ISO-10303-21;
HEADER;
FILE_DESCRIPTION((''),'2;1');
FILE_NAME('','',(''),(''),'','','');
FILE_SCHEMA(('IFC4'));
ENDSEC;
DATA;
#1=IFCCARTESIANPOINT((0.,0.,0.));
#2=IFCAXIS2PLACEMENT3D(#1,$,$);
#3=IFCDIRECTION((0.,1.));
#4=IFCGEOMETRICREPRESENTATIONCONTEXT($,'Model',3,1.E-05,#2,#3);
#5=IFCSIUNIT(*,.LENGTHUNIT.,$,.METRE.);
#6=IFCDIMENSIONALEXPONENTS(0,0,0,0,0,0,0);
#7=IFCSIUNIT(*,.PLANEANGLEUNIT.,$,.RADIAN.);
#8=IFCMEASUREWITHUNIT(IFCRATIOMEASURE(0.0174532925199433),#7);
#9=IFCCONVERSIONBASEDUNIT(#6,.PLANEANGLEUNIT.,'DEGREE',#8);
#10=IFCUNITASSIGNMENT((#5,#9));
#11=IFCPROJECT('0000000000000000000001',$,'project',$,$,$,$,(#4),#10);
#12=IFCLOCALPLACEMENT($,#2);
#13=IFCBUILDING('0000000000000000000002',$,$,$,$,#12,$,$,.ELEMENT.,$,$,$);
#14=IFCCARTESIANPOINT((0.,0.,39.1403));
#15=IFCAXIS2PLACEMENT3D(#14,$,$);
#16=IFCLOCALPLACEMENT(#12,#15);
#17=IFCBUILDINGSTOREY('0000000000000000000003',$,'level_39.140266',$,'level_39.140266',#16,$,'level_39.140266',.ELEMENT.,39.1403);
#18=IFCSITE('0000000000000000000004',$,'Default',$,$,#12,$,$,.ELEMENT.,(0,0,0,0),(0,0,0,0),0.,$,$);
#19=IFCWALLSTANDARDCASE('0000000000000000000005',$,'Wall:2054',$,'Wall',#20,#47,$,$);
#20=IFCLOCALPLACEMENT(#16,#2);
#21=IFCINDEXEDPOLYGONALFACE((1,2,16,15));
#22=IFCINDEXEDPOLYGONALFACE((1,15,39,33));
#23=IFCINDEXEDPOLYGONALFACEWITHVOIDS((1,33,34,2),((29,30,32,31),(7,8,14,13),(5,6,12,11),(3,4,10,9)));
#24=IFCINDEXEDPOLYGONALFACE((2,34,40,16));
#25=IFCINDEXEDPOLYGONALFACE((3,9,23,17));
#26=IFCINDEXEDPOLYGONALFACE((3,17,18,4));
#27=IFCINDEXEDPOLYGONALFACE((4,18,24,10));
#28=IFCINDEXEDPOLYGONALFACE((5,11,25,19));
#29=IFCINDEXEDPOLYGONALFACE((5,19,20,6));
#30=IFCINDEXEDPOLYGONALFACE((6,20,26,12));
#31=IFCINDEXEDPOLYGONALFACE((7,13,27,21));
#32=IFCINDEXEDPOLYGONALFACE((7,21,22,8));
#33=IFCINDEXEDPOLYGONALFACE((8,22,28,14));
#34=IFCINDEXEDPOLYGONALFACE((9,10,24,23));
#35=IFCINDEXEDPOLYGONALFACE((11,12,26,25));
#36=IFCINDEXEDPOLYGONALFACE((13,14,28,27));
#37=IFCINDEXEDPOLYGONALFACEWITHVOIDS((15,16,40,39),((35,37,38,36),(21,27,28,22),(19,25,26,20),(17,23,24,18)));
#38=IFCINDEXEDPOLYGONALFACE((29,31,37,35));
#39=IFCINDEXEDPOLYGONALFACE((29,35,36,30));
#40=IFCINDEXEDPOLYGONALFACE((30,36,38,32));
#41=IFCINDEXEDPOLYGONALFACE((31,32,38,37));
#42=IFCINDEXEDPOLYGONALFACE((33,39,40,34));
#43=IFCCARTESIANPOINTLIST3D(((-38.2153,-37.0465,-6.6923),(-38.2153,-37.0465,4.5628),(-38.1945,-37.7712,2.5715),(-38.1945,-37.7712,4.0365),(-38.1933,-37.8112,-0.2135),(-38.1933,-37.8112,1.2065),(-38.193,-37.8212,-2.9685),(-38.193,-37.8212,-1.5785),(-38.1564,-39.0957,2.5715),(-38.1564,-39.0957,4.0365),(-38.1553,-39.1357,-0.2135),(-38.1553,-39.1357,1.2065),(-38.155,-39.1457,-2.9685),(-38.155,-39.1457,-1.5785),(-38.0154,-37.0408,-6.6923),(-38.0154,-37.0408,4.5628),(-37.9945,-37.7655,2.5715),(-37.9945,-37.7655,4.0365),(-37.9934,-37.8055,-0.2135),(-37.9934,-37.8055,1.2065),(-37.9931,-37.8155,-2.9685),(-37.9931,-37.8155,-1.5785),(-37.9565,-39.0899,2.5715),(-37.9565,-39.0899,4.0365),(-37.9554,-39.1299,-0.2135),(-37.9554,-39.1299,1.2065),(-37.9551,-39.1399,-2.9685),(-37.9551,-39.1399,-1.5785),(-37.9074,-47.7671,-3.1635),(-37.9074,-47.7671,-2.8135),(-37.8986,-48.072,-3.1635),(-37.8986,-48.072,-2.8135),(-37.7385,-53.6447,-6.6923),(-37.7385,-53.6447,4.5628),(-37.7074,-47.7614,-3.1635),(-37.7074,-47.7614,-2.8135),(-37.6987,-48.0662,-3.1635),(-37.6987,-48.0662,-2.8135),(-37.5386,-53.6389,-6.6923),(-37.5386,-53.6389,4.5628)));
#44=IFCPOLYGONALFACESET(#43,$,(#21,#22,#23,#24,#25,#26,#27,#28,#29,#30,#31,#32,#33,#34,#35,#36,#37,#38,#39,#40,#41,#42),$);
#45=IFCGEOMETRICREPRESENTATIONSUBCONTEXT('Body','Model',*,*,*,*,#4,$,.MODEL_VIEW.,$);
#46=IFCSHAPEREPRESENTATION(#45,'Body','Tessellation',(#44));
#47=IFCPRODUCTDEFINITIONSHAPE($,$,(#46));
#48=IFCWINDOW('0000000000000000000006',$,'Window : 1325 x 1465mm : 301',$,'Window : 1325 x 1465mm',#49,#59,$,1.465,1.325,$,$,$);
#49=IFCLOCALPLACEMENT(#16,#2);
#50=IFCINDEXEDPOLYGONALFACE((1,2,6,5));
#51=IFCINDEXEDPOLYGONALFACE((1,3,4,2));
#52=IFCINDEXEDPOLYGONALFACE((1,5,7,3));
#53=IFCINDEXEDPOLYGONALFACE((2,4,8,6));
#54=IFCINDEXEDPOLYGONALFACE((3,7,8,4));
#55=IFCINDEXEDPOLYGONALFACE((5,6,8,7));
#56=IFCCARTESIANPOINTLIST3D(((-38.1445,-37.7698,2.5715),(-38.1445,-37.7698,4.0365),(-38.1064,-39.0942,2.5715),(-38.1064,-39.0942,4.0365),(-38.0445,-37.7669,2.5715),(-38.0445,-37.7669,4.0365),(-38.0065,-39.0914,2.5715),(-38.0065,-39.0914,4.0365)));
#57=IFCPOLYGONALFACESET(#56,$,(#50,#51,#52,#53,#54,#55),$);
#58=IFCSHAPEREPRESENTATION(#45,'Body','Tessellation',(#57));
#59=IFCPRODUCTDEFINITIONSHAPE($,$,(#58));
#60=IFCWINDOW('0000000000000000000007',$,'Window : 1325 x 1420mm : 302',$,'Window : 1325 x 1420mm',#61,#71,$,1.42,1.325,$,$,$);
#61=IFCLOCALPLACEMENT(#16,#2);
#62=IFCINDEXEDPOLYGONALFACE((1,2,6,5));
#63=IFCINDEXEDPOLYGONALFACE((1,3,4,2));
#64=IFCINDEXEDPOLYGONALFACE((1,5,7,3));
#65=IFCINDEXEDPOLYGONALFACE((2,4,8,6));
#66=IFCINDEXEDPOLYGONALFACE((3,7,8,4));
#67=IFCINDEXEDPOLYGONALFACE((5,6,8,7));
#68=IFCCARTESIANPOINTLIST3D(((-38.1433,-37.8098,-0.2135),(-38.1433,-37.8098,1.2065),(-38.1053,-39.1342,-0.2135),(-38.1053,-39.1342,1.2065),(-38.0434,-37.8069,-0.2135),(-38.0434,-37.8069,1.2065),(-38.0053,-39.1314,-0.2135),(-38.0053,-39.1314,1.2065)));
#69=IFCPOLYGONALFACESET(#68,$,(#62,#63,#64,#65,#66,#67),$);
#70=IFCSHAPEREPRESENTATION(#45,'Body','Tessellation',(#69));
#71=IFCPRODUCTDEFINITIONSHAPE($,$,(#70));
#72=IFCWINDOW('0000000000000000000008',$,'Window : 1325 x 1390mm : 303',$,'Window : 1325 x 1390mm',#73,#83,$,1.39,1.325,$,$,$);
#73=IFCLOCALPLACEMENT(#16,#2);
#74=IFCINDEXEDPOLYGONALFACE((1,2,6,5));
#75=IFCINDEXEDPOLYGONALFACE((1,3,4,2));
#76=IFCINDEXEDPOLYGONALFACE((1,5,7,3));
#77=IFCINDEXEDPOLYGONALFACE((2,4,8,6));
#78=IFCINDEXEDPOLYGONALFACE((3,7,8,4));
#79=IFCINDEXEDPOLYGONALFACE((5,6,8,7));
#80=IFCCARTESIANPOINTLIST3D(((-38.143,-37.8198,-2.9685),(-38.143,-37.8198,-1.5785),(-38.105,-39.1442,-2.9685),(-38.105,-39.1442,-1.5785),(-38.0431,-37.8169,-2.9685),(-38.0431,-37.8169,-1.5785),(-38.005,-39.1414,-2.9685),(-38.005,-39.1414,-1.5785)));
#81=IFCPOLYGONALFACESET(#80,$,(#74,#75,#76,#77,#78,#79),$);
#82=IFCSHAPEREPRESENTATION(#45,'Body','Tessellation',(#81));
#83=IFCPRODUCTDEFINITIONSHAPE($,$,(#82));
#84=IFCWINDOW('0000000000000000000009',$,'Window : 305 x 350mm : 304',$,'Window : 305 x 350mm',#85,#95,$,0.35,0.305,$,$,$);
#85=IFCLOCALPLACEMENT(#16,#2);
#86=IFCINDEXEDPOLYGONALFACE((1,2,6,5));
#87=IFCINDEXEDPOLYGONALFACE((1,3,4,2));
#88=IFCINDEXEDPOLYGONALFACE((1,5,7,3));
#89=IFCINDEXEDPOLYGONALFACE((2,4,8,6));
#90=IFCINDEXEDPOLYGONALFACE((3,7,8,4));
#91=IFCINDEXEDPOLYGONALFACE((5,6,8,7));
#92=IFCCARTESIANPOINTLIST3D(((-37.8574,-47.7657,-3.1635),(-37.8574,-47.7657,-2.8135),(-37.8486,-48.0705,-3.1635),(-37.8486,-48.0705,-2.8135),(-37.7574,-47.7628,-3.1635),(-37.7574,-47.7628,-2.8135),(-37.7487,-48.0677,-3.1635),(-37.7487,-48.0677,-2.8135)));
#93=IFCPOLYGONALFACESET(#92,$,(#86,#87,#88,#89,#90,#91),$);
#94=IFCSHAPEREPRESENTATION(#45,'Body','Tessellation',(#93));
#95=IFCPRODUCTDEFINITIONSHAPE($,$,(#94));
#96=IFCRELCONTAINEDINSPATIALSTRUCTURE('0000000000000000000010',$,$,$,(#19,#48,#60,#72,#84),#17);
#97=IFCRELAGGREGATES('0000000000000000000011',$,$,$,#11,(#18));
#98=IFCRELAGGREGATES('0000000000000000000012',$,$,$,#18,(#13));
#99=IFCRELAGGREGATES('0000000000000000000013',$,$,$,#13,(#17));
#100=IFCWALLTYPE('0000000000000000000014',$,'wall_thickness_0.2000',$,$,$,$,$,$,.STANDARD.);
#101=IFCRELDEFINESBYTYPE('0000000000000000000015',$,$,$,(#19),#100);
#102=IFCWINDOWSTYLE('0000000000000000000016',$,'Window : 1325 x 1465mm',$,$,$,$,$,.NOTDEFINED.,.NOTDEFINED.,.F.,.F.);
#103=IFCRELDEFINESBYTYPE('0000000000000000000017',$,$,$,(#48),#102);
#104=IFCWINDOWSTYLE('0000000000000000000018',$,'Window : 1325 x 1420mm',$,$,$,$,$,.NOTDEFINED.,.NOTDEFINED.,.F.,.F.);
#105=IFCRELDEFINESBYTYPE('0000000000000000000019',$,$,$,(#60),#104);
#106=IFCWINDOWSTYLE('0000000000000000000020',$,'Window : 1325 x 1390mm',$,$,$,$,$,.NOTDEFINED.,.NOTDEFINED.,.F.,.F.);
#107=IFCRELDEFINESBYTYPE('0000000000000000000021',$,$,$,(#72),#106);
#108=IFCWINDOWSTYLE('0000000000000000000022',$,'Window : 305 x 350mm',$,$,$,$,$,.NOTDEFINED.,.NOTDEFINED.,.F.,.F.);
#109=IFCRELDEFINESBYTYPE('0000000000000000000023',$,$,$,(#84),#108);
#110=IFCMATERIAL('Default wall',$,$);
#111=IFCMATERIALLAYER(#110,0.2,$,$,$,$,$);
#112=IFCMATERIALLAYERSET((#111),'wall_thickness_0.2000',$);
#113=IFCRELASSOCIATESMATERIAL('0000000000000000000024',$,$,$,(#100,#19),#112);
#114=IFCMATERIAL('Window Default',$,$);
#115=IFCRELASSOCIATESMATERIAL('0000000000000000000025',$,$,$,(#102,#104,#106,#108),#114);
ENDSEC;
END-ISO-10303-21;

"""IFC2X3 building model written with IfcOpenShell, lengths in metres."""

from ifc_helpers import new_model, entity, si_unit, converted_unit, direction, frame, frame_2d, origin, origin_2d_with_axis, place, context, subcontext, project, spatial, polyline, rectangle, outline, extrude, source, transform, mapped, material, layer, layer_set, layer_usage, type_object, type_shapes, element, fill, save


model = new_model("IFC2X3")

# Units and contexts
model_context = context("Model", 3, precision=1e-05, world=origin(), true_north=direction((0.0, 1.0)))
body_context = subcontext(model_context, "Body", "Model", "MODEL_VIEW")
ifc_project = project(units=[si_unit("LENGTHUNIT", "METRE"), converted_unit("PLANEANGLEUNIT", "DEGREE", entity("IfcRatioMeasure", 0.0174532925199433), si_unit("PLANEANGLEUNIT", "RADIAN"), dimensions=[0, 0, 0, 0, 0, 0, 0])], contexts=[model_context])

# Site, building, storey
placement_1 = place(None, origin())
site = spatial("IfcSite", under=ifc_project, at=placement_1, Name="Default", CompositionType="ELEMENT", RefLatitude=(0, 0, 0, 0), RefLongitude=(0, 0, 0, 0), RefElevation=0.0)
building = spatial("IfcBuilding", under=site, at=placement_1, CompositionType="ELEMENT")
storey_placement = place(placement_1, frame((0.0, 0.0, 39.1403)))
storey = spatial("IfcBuildingStorey", under=building, at=storey_placement, Name="level_39.140266", ObjectType="level_39.140266", LongName="level_39.140266", CompositionType="ELEMENT", Elevation=39.1403)

# Shared definitions
ifc_material_1 = material(Name="Default wall")
ifc_layer = layer(ifc_material_1, 0.2)
ifc_layer_set = layer_set([ifc_layer], Name="wall_thickness_0.2000")
ifc_layer_usage = layer_usage(ifc_layer_set, "AXIS2", "POSITIVE", -0.1)
wall_type = type_object("IfcWallType", Name="wall_thickness_0.2000", PredefinedType="STANDARD", material=ifc_layer_set)

# Shared definitions
ifc_material_2 = material(Name="Window Default")

# Wall, openings, windows
placement_2 = place(placement_1, frame((0.0, 0.0, 32.448)))
wall_1_placement = place(placement_2, frame((-37.6386, -53.6418, 0.0), z_axis=(0.0, 0.0, 1.0), x_axis=(-0.028711, 0.999588, 0.0)))
wall_1 = element("IfcWallStandardCase", 1, at=wall_1_placement, inside=storey, type_object=wall_type, material=ifc_layer_usage, Name="Wall:2054", ObjectType="Wall", context=body_context, shape_type="SweptSolid", body=[
    extrude(outline(polyline([(16.605, -0.1), (16.605, 0.1), (0.0, 0.1), (0.0, -0.1), (16.605, -0.1)])), origin(), (0.0, 0.0, 1.0), 11.2551),
])
opening_1_placement = place(wall_1_placement, frame((14.555, -0.1, 9.2638)))
opening_1 = element("IfcOpeningElement", 2, at=opening_1_placement, cuts=wall_1, ObjectType="Opening", context=body_context, shape_type="SweptSolid", body=[
    extrude(rectangle(XDim=1.325, YDim=1.465, at=frame_2d((0.7325, 0.6625), x_axis=(0.0, 1.0))), frame((0.0, 0.0, 0.0), z_axis=(0.0, 1.0, 0.0), x_axis=(0.0, 0.0, 1.0)), (0.0, 0.0, 1.0), 0.2),
])
opening_2_placement = place(wall_1_placement, frame((14.515, -0.1, 6.4788)))
opening_2 = element("IfcOpeningElement", 3, at=opening_2_placement, cuts=wall_1, ObjectType="Opening", context=body_context, shape_type="SweptSolid", body=[
    extrude(rectangle(XDim=1.325, YDim=1.42, at=frame_2d((0.71, 0.6625), x_axis=(0.0, 1.0))), frame((0.0, 0.0, 0.0), z_axis=(0.0, 1.0, 0.0), x_axis=(0.0, 0.0, 1.0)), (0.0, 0.0, 1.0), 0.2),
])
opening_3_placement = place(wall_1_placement, frame((14.505, -0.1, 3.7238)))
opening_3 = element("IfcOpeningElement", 4, at=opening_3_placement, cuts=wall_1, ObjectType="Opening", context=body_context, shape_type="SweptSolid", body=[
    extrude(rectangle(XDim=1.325, YDim=1.39, at=frame_2d((0.695, 0.6625), x_axis=(0.0, 1.0))), frame((0.0, 0.0, 0.0), z_axis=(0.0, 1.0, 0.0), x_axis=(0.0, 0.0, 1.0)), (0.0, 0.0, 1.0), 0.2),
])
opening_4_placement = place(wall_1_placement, frame((5.575, -0.1, 3.5288)))
opening_4 = element("IfcOpeningElement", 5, at=opening_4_placement, cuts=wall_1, ObjectType="Opening", context=body_context, shape_type="SweptSolid", body=[
    extrude(rectangle(XDim=0.305, YDim=0.35, at=frame_2d((0.175, 0.1525), x_axis=(0.0, 1.0))), frame((0.0, 0.0, 0.0), z_axis=(0.0, 1.0, 0.0), x_axis=(0.0, 0.0, 1.0)), (0.0, 0.0, 1.0), 0.2),
])
window_style_1 = type_object("IfcWindowStyle", Name="Window : 1325 x 1465mm", ConstructionType="NOTDEFINED", OperationType="NOTDEFINED", ParameterTakesPrecedence=False, Sizeable=False, material=ifc_material_2)
shared_shape_1 = source(origin(), body_context, "Body", "SweptSolid", [
    extrude(rectangle(XDim=0.1, YDim=1.325, at=origin_2d_with_axis()), frame((0.6625, 0.1, 0.0), z_axis=(0.0, 0.0, 1.0), x_axis=(0.0, 1.0, 0.0)), (0.0, 0.0, 1.0), 1.465),
])
type_shapes(window_style_1, [shared_shape_1])
window_1_placement = place(opening_1_placement, origin())
window_1 = element("IfcWindow", 6, at=window_1_placement, inside=storey, type_object=window_style_1, Name="Window : 1325 x 1465mm : 301", ObjectType="Window : 1325 x 1465mm", OverallHeight=1.465, OverallWidth=1.325, context=body_context, shape_type="MappedRepresentation", body=[
    mapped(shared_shape_1, transform((0.0, 0.0, 0.0), scale=1.0)),
])
fill(opening_1, window_1)
window_style_2 = type_object("IfcWindowStyle", Name="Window : 1325 x 1420mm", ConstructionType="NOTDEFINED", OperationType="NOTDEFINED", ParameterTakesPrecedence=False, Sizeable=False, material=ifc_material_2)
shared_shape_2 = source(origin(), body_context, "Body", "SweptSolid", [
    extrude(rectangle(XDim=0.1, YDim=1.325, at=origin_2d_with_axis()), frame((0.6625, 0.1, 0.0), z_axis=(0.0, 0.0, 1.0), x_axis=(0.0, 1.0, 0.0)), (0.0, 0.0, 1.0), 1.42),
])
type_shapes(window_style_2, [shared_shape_2])
window_2_placement = place(opening_2_placement, origin())
window_2 = element("IfcWindow", 7, at=window_2_placement, inside=storey, type_object=window_style_2, Name="Window : 1325 x 1420mm : 302", ObjectType="Window : 1325 x 1420mm", OverallHeight=1.42, OverallWidth=1.325, context=body_context, shape_type="MappedRepresentation", body=[
    mapped(shared_shape_2, transform((0.0, 0.0, 0.0), scale=1.0)),
])
fill(opening_2, window_2)
window_style_3 = type_object("IfcWindowStyle", Name="Window : 1325 x 1390mm", ConstructionType="NOTDEFINED", OperationType="NOTDEFINED", ParameterTakesPrecedence=False, Sizeable=False, material=ifc_material_2)
shared_shape_3 = source(origin(), body_context, "Body", "SweptSolid", [
    extrude(rectangle(XDim=0.1, YDim=1.325, at=origin_2d_with_axis()), frame((0.6625, 0.1, 0.0), z_axis=(0.0, 0.0, 1.0), x_axis=(0.0, 1.0, 0.0)), (0.0, 0.0, 1.0), 1.39),
])
type_shapes(window_style_3, [shared_shape_3])
window_3_placement = place(opening_3_placement, origin())
window_3 = element("IfcWindow", 8, at=window_3_placement, inside=storey, type_object=window_style_3, Name="Window : 1325 x 1390mm : 303", ObjectType="Window : 1325 x 1390mm", OverallHeight=1.39, OverallWidth=1.325, context=body_context, shape_type="MappedRepresentation", body=[
    mapped(shared_shape_3, transform((0.0, 0.0, 0.0), scale=1.0)),
])
fill(opening_3, window_3)
window_style_4 = type_object("IfcWindowStyle", Name="Window : 305 x 350mm", ConstructionType="NOTDEFINED", OperationType="NOTDEFINED", ParameterTakesPrecedence=False, Sizeable=False, material=ifc_material_2)
shared_shape_4 = source(origin(), body_context, "Body", "SweptSolid", [
    extrude(rectangle(XDim=0.1, YDim=0.305, at=origin_2d_with_axis()), frame((0.1525, 0.1, 0.0), z_axis=(0.0, 0.0, 1.0), x_axis=(0.0, 1.0, 0.0)), (0.0, 0.0, 1.0), 0.35),
])
type_shapes(window_style_4, [shared_shape_4])
window_4_placement = place(opening_4_placement, origin())
window_4 = element("IfcWindow", 9, at=window_4_placement, inside=storey, type_object=window_style_4, Name="Window : 305 x 350mm : 304", ObjectType="Window : 305 x 350mm", OverallHeight=0.35, OverallWidth=0.305, context=body_context, shape_type="MappedRepresentation", body=[
    mapped(shared_shape_4, transform((0.0, 0.0, 0.0), scale=1.0)),
])
fill(opening_4, window_4)

save(model, "model.ifc")
